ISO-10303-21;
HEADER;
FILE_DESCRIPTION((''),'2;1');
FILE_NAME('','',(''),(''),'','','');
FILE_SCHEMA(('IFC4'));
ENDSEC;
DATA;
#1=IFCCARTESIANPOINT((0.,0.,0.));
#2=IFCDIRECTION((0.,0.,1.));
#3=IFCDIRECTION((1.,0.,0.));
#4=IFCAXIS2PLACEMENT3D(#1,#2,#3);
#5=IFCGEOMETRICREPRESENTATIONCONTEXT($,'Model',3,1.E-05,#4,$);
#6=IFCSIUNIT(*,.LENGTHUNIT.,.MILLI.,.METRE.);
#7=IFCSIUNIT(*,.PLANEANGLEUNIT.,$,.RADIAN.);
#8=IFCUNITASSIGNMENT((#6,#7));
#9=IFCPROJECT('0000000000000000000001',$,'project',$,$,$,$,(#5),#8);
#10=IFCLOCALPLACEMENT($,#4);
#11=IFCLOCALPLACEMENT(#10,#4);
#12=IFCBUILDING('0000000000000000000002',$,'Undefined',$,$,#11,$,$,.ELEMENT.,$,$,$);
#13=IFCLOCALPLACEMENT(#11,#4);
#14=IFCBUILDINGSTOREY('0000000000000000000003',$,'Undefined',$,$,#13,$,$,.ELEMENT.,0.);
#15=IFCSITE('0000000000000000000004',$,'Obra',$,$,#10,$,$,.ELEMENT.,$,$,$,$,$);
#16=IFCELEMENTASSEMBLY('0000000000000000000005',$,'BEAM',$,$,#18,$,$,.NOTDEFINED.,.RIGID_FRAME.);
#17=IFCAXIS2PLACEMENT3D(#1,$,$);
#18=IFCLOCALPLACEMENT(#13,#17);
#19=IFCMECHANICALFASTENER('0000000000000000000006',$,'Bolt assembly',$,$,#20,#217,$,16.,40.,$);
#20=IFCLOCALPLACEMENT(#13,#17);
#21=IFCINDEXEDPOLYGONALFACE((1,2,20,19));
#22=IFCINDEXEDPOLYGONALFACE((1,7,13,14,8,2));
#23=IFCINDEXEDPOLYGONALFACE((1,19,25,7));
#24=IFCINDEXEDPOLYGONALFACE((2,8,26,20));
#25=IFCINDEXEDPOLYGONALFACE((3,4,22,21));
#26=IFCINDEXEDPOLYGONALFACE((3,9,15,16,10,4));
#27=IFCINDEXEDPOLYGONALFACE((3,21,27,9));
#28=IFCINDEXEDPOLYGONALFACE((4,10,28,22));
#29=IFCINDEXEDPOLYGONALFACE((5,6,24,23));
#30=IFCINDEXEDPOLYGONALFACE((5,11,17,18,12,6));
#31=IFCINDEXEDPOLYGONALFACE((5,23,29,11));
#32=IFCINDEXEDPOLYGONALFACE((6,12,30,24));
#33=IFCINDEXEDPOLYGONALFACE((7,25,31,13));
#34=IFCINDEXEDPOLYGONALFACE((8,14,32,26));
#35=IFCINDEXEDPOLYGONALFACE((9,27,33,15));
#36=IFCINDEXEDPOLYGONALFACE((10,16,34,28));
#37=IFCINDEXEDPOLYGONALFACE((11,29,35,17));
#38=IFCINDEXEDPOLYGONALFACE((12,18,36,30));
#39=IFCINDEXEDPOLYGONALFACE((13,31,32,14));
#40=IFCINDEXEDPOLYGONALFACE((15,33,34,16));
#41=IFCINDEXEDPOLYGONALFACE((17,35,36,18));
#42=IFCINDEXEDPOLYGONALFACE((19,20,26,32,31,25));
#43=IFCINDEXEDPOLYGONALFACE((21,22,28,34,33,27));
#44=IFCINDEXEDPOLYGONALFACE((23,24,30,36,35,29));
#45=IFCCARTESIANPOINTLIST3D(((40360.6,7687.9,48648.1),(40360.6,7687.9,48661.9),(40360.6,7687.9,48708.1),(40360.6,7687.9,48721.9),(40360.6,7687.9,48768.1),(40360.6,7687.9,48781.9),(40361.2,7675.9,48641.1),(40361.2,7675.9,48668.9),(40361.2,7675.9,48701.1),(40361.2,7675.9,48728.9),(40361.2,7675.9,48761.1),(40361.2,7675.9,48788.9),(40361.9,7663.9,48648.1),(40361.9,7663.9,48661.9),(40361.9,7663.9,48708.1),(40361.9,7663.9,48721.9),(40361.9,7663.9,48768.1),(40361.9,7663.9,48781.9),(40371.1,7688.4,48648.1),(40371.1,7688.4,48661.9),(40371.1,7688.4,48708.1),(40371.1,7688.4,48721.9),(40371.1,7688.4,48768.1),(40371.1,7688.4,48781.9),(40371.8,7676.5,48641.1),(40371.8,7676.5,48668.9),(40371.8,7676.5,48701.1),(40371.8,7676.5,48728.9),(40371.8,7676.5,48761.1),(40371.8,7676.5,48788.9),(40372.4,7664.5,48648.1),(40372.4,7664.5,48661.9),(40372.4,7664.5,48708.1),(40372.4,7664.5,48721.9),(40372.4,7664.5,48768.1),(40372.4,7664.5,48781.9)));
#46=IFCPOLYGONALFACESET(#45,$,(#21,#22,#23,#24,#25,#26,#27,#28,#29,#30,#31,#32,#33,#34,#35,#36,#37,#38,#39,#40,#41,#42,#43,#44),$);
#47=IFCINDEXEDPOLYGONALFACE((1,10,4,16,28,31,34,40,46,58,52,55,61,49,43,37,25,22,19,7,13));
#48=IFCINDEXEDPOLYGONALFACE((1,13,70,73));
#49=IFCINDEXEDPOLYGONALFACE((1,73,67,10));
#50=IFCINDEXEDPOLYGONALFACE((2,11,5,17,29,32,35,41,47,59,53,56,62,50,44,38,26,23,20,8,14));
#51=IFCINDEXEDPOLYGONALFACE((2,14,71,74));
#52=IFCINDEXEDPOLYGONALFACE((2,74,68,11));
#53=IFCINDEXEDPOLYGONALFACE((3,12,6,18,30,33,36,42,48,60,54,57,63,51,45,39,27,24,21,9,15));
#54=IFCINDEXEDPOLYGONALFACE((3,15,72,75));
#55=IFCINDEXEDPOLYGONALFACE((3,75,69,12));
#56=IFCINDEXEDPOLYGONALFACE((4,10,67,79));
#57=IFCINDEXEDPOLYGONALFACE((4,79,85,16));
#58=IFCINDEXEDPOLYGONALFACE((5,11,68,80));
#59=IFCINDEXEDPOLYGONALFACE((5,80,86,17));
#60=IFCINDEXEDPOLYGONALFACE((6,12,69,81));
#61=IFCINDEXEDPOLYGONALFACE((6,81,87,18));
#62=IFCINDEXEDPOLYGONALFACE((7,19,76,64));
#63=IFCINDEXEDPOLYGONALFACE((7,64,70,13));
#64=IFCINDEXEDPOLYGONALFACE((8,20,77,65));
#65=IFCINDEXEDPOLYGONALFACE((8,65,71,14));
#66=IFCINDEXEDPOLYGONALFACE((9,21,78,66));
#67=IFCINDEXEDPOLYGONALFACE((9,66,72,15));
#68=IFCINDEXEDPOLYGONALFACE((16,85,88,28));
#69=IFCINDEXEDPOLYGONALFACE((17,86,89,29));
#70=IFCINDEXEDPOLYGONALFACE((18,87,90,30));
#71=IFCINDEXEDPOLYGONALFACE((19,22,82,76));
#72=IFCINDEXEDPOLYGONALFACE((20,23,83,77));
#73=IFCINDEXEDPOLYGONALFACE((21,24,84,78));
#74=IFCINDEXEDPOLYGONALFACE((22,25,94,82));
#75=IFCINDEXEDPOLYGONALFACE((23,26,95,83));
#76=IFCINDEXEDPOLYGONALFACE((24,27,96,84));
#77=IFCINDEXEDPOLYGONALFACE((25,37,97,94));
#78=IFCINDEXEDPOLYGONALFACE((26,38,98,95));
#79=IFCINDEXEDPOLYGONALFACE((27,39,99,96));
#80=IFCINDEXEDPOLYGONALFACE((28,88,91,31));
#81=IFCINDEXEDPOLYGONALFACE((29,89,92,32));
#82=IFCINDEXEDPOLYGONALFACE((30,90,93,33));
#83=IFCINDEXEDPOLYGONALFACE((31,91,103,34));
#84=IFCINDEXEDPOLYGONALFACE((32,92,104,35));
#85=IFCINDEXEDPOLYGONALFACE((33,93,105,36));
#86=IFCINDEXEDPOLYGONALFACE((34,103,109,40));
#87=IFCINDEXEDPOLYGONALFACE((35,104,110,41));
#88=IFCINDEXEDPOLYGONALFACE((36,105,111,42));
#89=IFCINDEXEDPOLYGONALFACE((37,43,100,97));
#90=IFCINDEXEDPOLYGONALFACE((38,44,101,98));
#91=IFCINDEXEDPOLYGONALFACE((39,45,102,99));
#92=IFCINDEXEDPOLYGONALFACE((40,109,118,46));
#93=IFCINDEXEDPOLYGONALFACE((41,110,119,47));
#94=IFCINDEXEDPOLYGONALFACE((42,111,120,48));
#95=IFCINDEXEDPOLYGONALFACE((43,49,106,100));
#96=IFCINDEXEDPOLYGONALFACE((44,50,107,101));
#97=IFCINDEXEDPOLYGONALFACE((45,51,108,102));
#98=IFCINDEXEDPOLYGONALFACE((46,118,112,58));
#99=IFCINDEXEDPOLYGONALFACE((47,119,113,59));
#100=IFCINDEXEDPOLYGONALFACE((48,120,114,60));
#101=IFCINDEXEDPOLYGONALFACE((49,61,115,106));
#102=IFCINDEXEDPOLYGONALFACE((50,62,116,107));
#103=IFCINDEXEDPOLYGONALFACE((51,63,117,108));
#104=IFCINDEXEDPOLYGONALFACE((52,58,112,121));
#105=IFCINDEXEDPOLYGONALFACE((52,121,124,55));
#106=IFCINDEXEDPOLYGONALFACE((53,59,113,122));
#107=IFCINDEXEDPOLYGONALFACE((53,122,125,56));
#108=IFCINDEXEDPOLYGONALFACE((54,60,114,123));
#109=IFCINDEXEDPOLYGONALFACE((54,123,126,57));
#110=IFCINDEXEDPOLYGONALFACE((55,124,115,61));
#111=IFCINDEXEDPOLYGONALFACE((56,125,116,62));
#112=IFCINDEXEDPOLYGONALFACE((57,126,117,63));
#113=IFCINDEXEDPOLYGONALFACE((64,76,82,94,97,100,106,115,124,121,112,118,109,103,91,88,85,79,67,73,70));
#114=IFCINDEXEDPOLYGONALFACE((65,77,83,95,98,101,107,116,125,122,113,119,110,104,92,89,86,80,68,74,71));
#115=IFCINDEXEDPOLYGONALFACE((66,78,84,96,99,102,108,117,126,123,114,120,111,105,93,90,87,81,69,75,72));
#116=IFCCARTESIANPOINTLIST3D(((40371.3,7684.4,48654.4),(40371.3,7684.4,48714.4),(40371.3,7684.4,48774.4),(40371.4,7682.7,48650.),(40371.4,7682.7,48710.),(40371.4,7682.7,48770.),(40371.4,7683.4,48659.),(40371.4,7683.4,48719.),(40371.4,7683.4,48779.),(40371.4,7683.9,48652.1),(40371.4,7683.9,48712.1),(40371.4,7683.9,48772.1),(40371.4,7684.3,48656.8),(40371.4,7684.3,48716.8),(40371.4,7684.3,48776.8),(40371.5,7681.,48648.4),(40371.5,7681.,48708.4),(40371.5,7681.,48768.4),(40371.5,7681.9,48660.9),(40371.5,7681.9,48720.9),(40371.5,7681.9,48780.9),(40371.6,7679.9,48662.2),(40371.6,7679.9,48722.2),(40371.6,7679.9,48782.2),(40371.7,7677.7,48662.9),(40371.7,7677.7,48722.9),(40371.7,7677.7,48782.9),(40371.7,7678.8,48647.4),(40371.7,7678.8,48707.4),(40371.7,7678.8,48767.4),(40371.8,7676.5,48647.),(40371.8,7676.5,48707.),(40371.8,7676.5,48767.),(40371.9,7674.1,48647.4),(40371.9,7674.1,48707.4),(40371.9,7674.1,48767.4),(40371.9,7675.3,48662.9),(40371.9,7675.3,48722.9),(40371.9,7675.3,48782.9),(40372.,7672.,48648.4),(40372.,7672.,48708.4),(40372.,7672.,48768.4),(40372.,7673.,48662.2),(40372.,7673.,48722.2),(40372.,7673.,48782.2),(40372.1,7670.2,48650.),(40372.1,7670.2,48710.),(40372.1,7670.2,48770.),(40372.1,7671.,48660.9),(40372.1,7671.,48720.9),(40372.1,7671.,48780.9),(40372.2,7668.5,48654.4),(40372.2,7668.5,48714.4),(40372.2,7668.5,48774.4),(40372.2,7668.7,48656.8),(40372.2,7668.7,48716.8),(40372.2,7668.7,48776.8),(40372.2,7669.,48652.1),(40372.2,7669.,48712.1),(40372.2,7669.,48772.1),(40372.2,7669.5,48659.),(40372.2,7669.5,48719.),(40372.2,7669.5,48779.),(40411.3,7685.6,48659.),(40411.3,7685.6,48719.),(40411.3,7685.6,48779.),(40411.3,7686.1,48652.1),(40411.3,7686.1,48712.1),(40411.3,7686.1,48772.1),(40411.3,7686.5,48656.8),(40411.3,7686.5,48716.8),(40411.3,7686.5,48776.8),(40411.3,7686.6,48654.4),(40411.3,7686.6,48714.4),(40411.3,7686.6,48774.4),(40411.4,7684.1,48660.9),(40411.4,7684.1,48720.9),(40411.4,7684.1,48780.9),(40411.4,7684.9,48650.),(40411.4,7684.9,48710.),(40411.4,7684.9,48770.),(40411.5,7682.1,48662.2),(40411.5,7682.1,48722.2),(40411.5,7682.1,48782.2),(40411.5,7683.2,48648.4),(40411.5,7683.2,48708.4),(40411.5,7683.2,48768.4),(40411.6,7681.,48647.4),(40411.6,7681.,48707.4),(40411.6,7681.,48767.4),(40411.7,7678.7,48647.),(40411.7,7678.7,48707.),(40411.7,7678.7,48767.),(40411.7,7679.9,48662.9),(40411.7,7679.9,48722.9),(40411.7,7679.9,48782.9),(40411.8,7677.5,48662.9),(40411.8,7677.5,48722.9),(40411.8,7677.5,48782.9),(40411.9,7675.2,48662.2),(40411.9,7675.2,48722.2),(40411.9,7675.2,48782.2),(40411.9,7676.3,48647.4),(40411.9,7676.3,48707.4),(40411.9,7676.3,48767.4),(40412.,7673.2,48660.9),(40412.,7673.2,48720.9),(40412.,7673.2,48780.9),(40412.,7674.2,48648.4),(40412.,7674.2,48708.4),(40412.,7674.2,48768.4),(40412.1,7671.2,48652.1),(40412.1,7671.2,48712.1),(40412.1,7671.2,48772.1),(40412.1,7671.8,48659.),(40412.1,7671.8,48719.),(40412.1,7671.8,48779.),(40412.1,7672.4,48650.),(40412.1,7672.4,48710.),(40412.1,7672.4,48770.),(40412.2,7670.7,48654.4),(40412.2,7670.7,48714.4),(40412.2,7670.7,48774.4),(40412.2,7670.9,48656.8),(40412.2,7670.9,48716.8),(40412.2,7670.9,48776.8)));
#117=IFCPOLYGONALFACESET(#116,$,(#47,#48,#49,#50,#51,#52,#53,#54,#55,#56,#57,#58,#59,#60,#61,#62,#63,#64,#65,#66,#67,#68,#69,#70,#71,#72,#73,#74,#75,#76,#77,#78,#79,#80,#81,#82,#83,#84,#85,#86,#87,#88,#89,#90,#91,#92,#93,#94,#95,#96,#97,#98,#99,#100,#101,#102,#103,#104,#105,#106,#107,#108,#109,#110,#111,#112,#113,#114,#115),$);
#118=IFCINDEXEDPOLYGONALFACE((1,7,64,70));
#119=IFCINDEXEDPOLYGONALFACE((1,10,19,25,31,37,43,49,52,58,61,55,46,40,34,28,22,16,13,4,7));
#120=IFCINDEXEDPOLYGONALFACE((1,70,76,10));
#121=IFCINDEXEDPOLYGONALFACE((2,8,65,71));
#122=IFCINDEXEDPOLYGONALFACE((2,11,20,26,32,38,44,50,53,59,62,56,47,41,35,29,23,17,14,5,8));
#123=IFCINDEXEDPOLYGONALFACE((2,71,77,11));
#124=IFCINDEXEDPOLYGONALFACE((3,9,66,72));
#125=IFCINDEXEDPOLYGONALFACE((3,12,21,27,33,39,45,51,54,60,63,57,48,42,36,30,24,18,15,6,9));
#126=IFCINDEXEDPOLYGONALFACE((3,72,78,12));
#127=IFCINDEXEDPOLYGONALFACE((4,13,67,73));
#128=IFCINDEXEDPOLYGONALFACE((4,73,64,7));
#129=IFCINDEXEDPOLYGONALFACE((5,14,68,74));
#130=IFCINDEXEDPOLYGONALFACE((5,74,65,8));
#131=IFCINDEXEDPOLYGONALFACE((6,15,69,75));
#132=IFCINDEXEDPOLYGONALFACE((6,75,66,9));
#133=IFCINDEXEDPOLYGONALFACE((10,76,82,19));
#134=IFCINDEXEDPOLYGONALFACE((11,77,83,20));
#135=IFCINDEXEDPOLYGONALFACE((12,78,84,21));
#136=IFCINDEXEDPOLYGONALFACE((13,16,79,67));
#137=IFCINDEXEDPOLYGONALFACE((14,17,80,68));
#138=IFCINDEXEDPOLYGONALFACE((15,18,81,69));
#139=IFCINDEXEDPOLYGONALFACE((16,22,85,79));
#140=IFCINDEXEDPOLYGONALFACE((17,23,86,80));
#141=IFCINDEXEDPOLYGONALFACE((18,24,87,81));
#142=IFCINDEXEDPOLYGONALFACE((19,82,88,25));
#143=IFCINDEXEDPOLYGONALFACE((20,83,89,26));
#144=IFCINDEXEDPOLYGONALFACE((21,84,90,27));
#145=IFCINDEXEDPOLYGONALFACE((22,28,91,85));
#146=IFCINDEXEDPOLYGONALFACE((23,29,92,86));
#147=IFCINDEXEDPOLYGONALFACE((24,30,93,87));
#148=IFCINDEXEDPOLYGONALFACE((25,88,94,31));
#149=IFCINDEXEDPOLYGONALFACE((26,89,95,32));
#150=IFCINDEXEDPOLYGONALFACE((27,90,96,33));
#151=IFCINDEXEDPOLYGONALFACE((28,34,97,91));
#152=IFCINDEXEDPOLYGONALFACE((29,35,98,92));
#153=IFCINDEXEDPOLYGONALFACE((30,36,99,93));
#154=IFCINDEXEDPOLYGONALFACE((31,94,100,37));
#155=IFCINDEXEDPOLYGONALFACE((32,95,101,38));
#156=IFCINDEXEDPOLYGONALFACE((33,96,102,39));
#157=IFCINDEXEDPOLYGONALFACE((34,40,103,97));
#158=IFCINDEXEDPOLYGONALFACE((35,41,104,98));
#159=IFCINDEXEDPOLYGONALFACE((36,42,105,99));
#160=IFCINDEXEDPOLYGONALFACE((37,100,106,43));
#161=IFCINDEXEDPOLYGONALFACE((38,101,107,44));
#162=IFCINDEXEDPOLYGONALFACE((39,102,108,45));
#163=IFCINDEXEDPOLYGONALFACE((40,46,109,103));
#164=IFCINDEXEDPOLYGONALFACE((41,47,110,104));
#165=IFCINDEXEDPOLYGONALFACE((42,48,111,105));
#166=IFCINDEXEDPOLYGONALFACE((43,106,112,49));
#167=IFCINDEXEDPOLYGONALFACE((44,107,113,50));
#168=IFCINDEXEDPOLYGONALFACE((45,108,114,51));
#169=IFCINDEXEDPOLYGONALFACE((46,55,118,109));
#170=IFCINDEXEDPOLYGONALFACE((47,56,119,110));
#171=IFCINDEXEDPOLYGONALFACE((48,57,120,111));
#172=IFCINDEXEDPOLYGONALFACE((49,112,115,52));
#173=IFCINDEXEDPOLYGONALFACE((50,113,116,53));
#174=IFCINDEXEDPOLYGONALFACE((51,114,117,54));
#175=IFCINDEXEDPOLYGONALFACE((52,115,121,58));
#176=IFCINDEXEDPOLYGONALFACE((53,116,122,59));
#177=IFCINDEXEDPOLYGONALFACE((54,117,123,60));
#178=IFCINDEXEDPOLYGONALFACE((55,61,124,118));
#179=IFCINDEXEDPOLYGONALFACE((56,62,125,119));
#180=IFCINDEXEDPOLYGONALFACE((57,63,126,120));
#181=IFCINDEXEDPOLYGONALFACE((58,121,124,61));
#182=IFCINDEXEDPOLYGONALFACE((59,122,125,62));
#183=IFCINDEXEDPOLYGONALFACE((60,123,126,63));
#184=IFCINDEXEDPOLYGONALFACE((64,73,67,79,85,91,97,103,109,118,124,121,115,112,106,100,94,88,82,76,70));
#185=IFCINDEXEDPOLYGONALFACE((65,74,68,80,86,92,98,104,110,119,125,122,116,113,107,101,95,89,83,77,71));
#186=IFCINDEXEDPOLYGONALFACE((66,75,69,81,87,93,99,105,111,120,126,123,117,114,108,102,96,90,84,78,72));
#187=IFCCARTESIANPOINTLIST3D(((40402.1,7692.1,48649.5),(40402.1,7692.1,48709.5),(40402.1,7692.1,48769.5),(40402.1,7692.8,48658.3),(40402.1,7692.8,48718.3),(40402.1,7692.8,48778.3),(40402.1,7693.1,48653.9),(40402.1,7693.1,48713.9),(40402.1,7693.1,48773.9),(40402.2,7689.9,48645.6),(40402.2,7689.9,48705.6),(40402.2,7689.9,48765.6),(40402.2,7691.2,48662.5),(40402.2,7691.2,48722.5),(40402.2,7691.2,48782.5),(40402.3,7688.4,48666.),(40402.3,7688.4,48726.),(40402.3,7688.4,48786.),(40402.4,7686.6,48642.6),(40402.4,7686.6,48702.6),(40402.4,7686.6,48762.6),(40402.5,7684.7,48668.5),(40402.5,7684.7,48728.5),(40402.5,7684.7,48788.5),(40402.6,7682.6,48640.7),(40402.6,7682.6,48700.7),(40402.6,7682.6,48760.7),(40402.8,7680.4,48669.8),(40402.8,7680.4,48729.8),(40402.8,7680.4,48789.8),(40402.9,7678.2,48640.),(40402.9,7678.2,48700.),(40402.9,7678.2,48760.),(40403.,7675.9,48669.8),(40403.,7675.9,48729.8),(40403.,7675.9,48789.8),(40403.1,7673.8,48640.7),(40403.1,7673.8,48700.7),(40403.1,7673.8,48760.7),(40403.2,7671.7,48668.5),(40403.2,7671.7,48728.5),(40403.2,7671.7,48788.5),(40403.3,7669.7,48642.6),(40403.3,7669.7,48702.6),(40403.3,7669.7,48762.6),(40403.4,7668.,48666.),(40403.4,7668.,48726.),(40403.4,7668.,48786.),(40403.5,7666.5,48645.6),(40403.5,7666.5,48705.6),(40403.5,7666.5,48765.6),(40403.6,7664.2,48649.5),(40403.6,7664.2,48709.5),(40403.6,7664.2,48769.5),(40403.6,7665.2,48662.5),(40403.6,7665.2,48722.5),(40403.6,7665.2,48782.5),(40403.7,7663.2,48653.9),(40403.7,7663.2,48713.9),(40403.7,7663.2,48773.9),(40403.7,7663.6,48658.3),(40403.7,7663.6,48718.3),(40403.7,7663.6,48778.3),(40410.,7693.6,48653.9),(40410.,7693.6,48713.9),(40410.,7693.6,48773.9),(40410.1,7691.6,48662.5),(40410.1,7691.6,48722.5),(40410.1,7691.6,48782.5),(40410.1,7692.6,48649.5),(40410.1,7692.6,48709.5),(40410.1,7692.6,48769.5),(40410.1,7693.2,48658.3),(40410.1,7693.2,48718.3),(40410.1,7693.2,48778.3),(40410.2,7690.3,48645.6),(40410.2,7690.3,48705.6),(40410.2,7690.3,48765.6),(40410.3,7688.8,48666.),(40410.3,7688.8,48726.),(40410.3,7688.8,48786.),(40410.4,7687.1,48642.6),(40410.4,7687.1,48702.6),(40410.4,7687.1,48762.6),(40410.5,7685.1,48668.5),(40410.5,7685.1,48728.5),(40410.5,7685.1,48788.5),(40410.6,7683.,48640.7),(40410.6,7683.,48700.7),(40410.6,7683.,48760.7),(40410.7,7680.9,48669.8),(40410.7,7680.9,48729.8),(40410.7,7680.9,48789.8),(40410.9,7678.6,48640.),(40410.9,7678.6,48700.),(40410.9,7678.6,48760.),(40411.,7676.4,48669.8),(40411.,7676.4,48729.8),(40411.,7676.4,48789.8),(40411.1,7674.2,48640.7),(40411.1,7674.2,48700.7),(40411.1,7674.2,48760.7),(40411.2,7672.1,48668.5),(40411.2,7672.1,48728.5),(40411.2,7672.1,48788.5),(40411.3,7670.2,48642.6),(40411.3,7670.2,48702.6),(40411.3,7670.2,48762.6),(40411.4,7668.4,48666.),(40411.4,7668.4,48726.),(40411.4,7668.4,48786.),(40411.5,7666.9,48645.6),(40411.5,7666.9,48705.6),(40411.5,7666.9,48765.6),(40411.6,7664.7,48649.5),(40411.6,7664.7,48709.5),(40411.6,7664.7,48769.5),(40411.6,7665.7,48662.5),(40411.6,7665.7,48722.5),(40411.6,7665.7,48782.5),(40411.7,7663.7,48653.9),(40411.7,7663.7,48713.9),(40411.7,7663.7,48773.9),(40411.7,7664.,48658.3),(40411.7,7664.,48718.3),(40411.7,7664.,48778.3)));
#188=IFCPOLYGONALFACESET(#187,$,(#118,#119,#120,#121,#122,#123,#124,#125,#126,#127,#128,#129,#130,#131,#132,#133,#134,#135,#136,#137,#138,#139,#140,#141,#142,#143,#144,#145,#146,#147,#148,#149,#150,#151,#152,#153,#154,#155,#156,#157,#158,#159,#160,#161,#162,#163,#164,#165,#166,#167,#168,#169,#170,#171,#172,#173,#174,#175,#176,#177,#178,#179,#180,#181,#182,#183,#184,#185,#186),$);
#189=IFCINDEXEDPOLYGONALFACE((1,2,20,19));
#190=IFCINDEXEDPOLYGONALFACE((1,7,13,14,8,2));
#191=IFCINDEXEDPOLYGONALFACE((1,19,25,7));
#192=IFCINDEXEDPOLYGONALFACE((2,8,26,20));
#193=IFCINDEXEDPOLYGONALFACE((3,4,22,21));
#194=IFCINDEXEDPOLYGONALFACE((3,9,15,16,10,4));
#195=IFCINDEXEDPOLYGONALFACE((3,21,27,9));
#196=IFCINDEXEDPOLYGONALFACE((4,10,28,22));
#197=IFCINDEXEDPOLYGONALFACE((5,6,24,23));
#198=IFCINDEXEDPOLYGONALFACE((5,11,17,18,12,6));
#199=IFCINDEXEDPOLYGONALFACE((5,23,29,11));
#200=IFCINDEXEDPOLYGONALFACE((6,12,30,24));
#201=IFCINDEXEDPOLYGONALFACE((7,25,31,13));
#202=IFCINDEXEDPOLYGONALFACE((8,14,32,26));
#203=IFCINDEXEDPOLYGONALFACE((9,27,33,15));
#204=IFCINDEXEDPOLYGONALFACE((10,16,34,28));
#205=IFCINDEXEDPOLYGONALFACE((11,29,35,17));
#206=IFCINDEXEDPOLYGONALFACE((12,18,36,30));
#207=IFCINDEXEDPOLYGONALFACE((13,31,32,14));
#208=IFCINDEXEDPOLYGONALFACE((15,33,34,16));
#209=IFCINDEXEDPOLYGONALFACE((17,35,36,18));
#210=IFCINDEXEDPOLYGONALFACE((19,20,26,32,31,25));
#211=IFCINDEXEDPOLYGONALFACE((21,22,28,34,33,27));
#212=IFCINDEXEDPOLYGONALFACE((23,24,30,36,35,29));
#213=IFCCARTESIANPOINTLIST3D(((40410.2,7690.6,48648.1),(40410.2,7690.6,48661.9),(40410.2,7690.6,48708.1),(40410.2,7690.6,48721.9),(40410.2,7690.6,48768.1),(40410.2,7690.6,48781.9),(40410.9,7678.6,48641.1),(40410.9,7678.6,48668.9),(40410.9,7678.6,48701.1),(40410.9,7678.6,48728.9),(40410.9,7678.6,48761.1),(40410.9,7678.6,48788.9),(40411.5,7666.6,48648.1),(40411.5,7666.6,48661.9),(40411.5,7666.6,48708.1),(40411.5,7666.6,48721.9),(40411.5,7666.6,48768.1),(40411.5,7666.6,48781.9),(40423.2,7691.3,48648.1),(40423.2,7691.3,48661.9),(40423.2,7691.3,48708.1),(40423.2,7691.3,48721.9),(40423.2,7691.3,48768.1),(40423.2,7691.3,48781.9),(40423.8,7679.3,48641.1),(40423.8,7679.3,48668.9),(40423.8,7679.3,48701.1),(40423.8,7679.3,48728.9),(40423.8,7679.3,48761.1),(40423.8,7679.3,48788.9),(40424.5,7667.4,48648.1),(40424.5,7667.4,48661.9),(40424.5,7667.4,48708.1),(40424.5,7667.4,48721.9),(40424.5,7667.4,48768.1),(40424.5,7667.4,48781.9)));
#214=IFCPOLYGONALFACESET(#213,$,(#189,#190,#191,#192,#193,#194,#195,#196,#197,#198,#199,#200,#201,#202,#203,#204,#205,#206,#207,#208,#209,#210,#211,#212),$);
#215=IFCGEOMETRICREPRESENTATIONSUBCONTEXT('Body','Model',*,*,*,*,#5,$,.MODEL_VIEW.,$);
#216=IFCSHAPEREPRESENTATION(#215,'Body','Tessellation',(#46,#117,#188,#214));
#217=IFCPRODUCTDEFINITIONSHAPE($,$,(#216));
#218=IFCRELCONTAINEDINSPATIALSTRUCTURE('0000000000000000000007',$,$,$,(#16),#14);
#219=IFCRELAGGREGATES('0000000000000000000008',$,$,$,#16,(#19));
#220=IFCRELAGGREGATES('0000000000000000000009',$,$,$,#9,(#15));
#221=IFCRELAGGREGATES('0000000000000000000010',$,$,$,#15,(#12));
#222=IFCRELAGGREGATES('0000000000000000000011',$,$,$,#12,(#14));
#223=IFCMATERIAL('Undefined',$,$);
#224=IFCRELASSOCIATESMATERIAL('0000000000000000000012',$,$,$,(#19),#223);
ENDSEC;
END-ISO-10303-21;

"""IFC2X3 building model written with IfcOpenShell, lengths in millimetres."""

from ifc_helpers import new_model, si_unit, frame, origin_with_axes, origin_2d_with_axis, place, context, subcontext, project, spatial, polyline, circle, outline, extrude, source, transform, mapped, material, element, aggregate, save


model = new_model("IFC2X3")

# Units and contexts
model_context = context("Model", 3, precision=1e-05, world=origin_with_axes())
body_context = subcontext(model_context, "Body", "Model", "MODEL_VIEW")
ifc_project = project(units=[si_unit("LENGTHUNIT", "METRE", prefix="MILLI"), si_unit("PLANEANGLEUNIT", "RADIAN")], contexts=[model_context])

# Site, building, storey
site_placement = place(None, origin_with_axes())
site = spatial("IfcSite", under=ifc_project, at=site_placement, Name="Obra", CompositionType="ELEMENT")
building_placement = place(site_placement, origin_with_axes())
building = spatial("IfcBuilding", under=site, at=building_placement, Name="Undefined", CompositionType="ELEMENT")
storey_placement = place(building_placement, origin_with_axes())
storey = spatial("IfcBuildingStorey", under=building, at=storey_placement, Name="Undefined", CompositionType="ELEMENT", Elevation=0.0)

# Element assembly
assembly_1_placement = place(storey_placement, origin_with_axes())
assembly_1 = element("IfcElementAssembly", 1, at=assembly_1_placement, inside=storey, Name="BEAM", AssemblyPlace="NOTDEFINED", PredefinedType="RIGID_FRAME")

# Mechanical fastener
ifc_material_1 = material(Name="Undefined")
shared_shape_1 = source(origin_with_axes(), body_context, "Body", "SweptSolid", [
    extrude(outline(polyline([(13.9, 0.0), (6.9, 12.0), (-6.9, 12.0), (-13.9, 0.0), (-6.9, -12.0), (6.9, -12.0), (13.9, 0.0)])), frame((0.0, -44.8, 0.0), z_axis=(0.0, 1.0, 0.0), x_axis=(1.0, 0.0, 0.0)), (0.0, 0.0, 1.0), 10.6),
    extrude(circle(Radius=8.0, at=origin_2d_with_axis()), frame((0.0, -34.2, 0.0), z_axis=(0.0, 1.0, 0.0), x_axis=(1.0, 0.0, 0.0)), (0.0, 0.0, 1.0), 40.0),
    extrude(circle(Radius=15.0, at=origin_2d_with_axis()), frame((0.0, -3.1, 0.0), z_axis=(0.0, 1.0, 0.0), x_axis=(1.0, 0.0, 0.0)), (0.0, 0.0, 1.0), 8.0),
    extrude(outline(polyline([(13.9, 0.0), (6.9, 12.0), (-6.9, 12.0), (-13.9, 0.0), (-6.9, -12.0), (6.9, -12.0), (13.9, 0.0)])), frame((0.0, 4.9, 0.0), z_axis=(0.0, 1.0, 0.0), x_axis=(1.0, 0.0, 0.0)), (0.0, 0.0, 1.0), 13.0),
])
mechanical_fastener_1_placement = place(assembly_1_placement, frame((40403.2, 7728.3, 48835.0), z_axis=(0.055152, -0.998478, 0.0), x_axis=(0.0, 0.0, -1.0)))
mechanical_fastener_1 = element("IfcMechanicalFastener", 2, at=mechanical_fastener_1_placement, material=ifc_material_1, Name="Bolt assembly", NominalDiameter=16.0, NominalLength=40.0, context=body_context, shape_type="MappedRepresentation", body=[
    mapped(shared_shape_1, transform((60.0, 0.0, 50.0))),
    mapped(shared_shape_1, transform((120.0, 0.0, 50.0))),
    mapped(shared_shape_1, transform((180.0, 0.0, 50.0))),
])

aggregate(assembly_1, [mechanical_fastener_1])

save(model, "model.ifc")
